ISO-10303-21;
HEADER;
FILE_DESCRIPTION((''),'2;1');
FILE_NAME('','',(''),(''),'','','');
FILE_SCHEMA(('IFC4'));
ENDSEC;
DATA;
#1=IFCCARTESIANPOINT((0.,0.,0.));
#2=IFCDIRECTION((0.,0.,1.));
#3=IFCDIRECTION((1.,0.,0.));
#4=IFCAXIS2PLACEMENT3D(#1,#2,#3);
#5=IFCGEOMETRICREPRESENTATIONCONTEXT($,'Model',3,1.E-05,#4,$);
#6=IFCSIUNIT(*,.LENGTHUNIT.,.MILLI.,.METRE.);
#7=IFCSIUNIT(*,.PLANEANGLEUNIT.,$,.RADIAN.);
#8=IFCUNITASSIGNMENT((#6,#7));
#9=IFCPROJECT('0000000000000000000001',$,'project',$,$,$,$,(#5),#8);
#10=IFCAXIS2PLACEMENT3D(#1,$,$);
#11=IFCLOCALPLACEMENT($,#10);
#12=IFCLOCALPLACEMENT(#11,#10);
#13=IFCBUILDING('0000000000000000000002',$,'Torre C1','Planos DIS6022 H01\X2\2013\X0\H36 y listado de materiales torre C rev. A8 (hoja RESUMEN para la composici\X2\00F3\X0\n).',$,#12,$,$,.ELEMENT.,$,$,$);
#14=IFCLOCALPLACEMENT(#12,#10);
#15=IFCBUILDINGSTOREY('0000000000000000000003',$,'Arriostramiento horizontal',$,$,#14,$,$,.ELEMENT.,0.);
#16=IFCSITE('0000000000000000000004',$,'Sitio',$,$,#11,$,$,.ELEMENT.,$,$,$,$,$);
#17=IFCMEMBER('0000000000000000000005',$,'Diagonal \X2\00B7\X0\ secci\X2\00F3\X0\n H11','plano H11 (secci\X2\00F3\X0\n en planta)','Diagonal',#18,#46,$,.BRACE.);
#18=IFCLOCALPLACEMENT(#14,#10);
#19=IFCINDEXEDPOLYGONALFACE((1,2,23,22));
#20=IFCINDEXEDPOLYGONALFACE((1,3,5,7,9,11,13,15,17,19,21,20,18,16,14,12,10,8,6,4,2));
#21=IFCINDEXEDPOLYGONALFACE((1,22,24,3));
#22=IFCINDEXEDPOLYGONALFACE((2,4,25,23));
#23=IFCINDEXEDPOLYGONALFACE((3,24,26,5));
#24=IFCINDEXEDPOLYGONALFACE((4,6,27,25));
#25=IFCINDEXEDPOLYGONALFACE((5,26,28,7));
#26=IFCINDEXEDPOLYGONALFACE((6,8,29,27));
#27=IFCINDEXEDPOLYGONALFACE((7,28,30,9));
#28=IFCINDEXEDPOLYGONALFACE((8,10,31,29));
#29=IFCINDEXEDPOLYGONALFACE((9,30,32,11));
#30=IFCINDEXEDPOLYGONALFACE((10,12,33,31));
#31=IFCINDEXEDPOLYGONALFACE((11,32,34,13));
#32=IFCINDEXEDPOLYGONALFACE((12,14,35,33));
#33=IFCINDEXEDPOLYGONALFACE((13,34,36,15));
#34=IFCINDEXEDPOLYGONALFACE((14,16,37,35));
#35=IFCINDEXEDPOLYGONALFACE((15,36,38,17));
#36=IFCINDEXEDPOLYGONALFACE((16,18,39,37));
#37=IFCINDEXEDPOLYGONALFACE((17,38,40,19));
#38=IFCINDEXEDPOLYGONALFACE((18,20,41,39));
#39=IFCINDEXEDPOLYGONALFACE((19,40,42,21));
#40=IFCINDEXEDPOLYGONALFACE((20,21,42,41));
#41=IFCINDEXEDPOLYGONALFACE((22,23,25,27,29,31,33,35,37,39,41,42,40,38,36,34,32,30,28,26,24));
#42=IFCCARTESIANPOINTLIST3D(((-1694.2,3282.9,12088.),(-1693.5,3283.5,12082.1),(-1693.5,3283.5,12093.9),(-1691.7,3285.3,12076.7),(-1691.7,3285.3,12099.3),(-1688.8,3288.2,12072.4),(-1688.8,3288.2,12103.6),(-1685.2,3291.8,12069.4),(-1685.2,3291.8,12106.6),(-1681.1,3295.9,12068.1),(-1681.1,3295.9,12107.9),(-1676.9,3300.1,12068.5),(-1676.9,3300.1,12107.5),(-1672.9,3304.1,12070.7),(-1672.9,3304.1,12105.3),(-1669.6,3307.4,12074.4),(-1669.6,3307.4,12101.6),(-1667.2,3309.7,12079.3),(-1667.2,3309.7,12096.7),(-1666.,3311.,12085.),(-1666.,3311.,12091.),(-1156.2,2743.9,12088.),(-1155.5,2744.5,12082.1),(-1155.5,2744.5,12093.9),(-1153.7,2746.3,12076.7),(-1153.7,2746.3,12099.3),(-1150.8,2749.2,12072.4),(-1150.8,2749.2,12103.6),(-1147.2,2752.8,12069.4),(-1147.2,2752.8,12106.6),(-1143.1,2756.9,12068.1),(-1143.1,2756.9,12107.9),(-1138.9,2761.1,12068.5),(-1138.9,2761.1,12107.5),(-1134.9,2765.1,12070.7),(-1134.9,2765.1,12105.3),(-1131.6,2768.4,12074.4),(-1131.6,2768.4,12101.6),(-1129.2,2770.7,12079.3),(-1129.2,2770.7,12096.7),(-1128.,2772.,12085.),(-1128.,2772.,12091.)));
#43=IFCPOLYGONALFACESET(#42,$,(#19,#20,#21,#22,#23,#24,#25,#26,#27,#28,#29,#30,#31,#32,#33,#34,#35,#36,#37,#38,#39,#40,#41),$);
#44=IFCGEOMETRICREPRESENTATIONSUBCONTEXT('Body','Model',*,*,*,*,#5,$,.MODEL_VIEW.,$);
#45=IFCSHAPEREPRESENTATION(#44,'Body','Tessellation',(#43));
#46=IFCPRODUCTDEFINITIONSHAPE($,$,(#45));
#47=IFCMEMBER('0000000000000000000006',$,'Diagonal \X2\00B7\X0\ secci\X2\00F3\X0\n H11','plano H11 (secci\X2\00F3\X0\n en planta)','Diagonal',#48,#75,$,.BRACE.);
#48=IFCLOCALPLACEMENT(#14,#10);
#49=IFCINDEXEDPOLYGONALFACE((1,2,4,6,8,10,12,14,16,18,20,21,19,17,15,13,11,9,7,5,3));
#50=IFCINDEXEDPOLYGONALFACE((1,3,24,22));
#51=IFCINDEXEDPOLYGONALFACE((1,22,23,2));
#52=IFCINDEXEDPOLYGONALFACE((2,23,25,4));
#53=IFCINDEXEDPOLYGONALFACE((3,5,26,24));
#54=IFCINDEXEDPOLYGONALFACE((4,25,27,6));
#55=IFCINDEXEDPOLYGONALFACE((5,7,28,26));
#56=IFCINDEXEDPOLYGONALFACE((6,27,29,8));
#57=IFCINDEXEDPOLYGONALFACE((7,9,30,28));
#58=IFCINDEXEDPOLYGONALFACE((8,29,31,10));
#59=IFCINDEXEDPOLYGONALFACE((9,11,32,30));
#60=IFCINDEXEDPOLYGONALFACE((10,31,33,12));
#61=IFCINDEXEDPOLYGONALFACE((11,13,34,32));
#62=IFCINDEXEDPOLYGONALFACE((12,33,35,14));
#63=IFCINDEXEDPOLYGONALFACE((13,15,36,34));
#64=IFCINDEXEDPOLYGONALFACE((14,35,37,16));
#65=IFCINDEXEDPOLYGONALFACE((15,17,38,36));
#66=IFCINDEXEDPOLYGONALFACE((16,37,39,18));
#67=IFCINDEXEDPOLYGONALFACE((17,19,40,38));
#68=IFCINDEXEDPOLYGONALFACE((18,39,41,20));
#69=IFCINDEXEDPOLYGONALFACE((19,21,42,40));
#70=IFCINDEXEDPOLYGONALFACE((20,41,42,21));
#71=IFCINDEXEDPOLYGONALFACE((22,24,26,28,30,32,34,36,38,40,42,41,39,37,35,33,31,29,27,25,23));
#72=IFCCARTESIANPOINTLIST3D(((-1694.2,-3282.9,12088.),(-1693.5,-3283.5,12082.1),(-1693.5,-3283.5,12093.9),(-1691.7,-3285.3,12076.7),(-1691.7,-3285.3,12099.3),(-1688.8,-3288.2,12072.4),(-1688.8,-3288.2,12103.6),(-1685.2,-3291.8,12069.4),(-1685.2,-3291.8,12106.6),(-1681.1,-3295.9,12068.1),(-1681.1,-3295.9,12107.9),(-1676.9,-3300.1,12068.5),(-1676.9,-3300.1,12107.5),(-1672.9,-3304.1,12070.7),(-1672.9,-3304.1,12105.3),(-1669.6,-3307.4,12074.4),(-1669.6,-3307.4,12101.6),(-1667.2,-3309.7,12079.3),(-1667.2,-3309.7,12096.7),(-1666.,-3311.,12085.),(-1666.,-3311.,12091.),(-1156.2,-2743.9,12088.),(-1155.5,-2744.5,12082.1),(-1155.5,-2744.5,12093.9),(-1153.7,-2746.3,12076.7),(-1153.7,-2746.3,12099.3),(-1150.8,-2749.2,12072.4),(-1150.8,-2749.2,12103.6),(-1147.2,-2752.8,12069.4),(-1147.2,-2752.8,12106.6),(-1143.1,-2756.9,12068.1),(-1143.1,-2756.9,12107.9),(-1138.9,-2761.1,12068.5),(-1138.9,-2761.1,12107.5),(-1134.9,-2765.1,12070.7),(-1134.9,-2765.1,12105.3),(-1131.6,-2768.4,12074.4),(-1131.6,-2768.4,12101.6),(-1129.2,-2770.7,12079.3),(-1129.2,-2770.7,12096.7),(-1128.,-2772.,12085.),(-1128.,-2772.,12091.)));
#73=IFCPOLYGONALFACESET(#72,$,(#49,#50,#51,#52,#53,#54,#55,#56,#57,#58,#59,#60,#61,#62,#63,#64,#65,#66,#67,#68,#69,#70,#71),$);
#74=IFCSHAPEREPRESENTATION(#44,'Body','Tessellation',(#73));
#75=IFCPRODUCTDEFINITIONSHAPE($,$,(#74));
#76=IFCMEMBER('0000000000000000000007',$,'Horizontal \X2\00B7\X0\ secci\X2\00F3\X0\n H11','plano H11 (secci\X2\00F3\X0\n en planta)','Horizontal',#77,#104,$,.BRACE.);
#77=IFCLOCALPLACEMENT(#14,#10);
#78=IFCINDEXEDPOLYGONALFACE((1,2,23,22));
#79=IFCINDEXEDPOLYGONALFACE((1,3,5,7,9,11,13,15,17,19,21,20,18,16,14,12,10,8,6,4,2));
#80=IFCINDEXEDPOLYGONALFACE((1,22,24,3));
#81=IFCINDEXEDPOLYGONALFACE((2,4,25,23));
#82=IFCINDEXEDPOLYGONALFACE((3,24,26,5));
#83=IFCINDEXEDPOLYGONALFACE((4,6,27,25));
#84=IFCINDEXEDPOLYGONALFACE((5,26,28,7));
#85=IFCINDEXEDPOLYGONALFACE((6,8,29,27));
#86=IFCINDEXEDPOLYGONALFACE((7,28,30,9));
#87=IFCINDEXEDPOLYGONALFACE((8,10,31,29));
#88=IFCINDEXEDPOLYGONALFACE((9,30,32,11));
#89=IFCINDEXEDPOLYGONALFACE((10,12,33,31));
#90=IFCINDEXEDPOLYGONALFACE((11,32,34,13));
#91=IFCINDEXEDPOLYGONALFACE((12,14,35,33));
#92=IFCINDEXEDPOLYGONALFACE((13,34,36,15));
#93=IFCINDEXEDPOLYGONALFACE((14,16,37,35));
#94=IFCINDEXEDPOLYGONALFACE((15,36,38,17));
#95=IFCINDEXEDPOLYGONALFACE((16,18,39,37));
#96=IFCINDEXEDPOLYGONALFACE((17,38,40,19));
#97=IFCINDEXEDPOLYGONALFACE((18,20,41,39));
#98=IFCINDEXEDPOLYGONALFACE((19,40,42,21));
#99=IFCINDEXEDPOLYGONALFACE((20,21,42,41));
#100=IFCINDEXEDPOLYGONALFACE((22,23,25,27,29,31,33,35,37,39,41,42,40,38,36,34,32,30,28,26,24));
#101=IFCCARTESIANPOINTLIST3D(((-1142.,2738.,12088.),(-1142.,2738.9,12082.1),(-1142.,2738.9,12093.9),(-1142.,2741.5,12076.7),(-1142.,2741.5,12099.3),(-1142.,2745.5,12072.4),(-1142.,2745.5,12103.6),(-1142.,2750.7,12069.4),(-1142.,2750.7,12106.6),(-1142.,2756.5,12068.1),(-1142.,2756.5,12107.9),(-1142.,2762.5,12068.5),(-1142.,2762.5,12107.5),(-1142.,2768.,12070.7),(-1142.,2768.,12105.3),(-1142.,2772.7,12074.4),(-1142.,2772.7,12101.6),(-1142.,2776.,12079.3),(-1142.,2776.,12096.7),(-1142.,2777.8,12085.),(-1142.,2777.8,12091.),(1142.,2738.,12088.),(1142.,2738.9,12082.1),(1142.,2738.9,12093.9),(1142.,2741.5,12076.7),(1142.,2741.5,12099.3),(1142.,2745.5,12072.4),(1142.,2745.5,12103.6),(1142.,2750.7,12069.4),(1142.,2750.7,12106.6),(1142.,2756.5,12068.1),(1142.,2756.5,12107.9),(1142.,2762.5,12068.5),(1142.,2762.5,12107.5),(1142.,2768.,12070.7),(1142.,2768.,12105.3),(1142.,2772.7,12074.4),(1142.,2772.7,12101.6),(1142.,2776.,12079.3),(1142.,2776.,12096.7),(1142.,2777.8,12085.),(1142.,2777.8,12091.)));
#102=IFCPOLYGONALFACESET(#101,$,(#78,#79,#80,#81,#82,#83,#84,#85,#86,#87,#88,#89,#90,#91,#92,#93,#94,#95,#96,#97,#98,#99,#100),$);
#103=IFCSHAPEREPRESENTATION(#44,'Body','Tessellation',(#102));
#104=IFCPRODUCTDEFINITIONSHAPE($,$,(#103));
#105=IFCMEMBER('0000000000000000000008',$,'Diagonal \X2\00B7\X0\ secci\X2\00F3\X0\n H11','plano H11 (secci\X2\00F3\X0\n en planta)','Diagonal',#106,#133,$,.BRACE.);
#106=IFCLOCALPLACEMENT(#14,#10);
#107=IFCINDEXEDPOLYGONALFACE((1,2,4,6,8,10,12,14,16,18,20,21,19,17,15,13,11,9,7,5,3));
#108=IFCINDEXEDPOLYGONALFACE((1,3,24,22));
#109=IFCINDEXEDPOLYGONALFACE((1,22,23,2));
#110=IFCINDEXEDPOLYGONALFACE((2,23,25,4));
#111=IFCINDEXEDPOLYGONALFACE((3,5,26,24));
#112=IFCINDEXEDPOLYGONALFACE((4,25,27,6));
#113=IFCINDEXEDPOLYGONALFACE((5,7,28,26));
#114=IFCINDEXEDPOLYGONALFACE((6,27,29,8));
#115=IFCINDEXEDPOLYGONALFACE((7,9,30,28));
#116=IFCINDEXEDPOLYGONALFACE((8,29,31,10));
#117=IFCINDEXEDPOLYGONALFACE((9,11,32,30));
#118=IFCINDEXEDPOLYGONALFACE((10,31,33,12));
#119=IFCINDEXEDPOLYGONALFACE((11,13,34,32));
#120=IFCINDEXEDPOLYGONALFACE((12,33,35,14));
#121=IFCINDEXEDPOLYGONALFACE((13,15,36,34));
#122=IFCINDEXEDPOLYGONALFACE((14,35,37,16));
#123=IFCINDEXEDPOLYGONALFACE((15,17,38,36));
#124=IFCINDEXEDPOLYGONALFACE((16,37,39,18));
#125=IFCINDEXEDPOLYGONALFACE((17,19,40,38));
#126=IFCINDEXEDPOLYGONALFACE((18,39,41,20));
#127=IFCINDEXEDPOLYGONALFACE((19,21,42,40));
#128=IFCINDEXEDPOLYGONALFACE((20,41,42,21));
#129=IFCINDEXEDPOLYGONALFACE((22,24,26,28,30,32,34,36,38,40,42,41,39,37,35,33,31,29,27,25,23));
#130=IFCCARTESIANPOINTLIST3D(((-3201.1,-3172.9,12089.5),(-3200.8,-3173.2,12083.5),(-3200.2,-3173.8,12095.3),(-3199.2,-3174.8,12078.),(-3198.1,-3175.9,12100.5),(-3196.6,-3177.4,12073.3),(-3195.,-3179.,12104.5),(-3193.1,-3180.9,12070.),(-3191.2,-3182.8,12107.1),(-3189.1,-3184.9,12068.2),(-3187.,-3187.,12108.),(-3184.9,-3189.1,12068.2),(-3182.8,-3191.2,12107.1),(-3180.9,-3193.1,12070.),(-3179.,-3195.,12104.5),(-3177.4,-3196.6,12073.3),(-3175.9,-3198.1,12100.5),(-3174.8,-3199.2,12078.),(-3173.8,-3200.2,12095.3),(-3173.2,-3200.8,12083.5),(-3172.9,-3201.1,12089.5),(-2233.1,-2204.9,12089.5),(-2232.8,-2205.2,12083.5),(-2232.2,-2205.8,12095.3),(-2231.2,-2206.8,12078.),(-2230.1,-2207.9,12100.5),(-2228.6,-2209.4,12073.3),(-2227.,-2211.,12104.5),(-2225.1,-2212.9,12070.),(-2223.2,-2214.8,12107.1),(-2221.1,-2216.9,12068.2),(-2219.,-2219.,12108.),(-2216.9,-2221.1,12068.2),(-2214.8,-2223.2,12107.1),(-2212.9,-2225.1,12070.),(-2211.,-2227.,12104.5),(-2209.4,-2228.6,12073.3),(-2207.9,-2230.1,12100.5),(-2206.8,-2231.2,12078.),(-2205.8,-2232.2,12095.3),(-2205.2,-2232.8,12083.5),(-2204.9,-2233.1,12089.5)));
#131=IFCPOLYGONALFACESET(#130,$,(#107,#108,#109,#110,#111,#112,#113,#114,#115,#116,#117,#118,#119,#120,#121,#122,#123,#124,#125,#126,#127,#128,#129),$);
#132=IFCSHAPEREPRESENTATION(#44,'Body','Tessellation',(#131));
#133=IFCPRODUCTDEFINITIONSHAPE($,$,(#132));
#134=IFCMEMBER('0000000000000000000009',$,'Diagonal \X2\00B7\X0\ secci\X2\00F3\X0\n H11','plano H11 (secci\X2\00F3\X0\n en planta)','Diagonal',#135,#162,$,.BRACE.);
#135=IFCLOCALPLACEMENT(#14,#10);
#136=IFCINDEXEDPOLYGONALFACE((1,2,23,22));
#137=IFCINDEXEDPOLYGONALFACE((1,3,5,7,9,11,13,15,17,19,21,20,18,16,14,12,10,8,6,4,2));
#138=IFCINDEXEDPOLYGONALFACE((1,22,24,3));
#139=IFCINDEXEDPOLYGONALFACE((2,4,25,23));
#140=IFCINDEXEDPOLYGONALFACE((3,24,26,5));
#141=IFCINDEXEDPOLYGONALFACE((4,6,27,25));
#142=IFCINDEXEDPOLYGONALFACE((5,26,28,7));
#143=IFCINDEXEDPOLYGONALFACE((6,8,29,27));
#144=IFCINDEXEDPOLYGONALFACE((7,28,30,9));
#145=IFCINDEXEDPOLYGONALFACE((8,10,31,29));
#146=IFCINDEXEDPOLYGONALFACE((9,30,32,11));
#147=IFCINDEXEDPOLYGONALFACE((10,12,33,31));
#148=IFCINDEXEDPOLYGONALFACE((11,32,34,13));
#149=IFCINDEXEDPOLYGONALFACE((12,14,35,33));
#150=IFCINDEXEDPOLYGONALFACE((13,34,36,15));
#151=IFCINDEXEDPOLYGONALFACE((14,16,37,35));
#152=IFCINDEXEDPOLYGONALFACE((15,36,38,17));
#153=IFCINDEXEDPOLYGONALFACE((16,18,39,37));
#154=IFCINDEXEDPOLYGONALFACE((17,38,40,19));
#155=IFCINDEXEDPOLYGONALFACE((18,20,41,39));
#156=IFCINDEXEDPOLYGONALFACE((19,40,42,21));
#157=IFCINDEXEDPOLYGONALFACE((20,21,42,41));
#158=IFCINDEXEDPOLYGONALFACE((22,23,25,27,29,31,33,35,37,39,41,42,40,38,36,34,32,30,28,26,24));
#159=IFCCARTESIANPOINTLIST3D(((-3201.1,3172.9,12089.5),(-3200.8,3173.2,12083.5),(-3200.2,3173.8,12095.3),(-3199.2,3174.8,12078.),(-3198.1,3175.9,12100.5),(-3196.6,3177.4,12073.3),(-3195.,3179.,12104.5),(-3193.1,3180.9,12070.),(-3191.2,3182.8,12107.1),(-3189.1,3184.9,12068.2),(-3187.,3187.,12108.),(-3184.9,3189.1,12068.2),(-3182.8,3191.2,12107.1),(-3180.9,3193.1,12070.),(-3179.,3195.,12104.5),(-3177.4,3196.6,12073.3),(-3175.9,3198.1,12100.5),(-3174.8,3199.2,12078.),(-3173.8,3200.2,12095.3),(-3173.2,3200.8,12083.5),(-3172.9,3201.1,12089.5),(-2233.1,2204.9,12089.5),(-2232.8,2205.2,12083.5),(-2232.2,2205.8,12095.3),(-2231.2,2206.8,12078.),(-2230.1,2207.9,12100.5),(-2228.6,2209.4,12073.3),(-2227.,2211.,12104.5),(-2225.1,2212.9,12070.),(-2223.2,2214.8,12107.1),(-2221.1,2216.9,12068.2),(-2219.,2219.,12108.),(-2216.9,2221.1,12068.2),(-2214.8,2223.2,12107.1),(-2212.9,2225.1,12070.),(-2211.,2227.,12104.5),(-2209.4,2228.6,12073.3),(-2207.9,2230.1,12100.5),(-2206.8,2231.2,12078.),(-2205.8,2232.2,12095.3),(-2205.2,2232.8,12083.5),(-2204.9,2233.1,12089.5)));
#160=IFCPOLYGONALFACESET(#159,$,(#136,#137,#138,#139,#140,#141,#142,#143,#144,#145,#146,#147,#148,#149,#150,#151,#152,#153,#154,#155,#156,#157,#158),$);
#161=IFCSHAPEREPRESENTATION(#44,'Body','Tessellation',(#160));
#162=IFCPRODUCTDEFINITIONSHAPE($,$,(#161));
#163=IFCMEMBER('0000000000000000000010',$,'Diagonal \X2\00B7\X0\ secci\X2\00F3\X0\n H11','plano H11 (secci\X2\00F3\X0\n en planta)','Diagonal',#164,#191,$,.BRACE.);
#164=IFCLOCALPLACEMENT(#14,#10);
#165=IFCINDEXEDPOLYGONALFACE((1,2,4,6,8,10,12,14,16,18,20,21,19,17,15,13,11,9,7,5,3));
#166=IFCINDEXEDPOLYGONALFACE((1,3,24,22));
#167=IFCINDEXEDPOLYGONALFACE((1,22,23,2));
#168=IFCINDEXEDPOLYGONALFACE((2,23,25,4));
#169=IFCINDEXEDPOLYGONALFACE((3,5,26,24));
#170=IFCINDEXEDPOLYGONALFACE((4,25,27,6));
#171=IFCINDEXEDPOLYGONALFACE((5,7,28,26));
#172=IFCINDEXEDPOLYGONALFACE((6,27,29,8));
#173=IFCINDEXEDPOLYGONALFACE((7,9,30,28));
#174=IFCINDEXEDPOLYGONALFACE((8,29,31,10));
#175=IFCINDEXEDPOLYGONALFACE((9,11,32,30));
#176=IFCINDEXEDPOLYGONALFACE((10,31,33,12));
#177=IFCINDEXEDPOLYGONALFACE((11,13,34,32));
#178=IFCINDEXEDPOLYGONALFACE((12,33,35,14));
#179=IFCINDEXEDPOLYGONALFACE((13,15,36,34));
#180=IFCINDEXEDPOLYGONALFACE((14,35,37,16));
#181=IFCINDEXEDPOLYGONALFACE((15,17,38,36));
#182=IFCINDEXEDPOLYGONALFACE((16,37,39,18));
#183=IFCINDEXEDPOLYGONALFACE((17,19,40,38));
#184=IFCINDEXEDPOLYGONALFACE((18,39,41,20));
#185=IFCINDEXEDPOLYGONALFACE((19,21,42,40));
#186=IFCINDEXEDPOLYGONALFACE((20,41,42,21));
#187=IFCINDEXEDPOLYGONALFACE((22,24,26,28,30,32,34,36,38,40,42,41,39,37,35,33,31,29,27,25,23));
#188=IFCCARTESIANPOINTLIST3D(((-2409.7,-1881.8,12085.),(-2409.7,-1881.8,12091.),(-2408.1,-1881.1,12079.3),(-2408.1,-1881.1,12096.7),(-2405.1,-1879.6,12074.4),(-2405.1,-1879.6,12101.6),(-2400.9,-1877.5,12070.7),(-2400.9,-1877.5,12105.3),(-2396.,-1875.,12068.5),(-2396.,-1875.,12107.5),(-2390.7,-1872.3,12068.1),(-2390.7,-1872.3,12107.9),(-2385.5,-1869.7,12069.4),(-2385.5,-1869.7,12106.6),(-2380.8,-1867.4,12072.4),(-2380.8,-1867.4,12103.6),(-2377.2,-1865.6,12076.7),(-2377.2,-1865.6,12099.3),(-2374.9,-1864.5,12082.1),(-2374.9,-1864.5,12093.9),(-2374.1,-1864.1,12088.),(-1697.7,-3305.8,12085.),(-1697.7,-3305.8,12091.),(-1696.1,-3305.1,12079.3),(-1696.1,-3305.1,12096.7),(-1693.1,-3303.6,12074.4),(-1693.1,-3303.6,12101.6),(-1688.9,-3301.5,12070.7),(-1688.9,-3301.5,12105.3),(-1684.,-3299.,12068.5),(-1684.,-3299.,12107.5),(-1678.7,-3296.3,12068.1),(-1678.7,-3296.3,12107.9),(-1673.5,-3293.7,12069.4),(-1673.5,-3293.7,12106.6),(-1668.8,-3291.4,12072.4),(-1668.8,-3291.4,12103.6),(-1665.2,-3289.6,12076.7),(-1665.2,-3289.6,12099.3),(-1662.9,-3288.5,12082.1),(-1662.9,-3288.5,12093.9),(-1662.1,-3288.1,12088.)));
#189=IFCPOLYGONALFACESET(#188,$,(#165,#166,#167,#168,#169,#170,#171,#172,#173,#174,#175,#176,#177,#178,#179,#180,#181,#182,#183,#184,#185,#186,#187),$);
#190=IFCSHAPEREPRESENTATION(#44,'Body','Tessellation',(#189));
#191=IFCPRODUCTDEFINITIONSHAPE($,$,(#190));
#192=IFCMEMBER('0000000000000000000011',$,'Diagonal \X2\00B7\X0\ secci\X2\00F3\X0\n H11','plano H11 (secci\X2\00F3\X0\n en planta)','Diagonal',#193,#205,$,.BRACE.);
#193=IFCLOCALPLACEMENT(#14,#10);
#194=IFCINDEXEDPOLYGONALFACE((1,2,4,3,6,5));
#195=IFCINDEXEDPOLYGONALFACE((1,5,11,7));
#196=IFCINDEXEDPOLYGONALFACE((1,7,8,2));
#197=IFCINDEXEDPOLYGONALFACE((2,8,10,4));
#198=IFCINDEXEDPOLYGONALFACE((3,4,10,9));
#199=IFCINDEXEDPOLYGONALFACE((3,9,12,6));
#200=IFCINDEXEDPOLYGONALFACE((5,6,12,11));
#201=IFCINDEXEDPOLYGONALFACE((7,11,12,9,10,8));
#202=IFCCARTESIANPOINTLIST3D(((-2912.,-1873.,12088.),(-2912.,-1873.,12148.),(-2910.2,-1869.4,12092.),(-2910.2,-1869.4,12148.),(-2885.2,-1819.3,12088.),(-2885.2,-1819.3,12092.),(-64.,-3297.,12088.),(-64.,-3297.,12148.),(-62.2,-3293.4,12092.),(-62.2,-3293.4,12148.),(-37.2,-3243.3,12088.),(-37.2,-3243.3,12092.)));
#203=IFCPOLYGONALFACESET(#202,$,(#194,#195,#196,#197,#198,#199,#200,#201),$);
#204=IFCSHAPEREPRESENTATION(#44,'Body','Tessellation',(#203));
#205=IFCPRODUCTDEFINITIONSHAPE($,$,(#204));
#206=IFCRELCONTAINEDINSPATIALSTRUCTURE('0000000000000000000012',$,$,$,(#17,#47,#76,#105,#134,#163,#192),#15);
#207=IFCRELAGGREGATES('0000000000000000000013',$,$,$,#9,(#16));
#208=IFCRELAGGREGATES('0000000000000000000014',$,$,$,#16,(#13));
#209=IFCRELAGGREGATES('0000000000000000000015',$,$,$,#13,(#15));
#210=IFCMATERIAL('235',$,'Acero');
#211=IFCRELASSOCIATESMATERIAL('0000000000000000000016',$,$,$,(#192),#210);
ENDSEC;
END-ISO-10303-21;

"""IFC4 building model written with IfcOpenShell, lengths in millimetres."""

from ifc_helpers import new_model, si_unit, frame, frame_2d, origin, origin_with_axes, place, context, subcontext, project, spatial, circle, l_section, extrude, material, element, save


model = new_model("IFC4")

# Units and contexts
model_context = context("Model", 3, precision=1e-05, world=origin_with_axes())
body_context = subcontext(model_context, "Body", "Model", "MODEL_VIEW")
ifc_project = project(units=[si_unit("LENGTHUNIT", "METRE", prefix="MILLI"), si_unit("PLANEANGLEUNIT", "RADIAN")], contexts=[model_context])

# Site, building, storey
site_placement = place(None, origin())
site = spatial("IfcSite", under=ifc_project, at=site_placement, Name="Sitio", CompositionType="ELEMENT")
building_placement = place(site_placement, origin())
building = spatial("IfcBuilding", under=site, at=building_placement, Name="Torre C1", Description="Planos DIS6022 H01–H36 y listado de materiales torre C rev. A8 (hoja RESUMEN para la composición).", CompositionType="ELEMENT")
storey_placement = place(building_placement, origin())
storey = spatial("IfcBuildingStorey", under=building, at=storey_placement, Name="Arriostramiento horizontal", CompositionType="ELEMENT", Elevation=0.0)

# Members
for number, where, z_axis, x_axis, name in (
    (1, (-1680.0, 3297.0, 12088.0), (0.70645, -0.707763, 0.0), (-0.707763, -0.70645, 0.0), "Diagonal · sección H11"),
    (2, (-1680.0, -3297.0, 12088.0), (0.70645, 0.707763, 0.0), (-0.707763, 0.70645, 0.0), "Diagonal · sección H11"),
):
    element("IfcMember", number, at=place(storey_placement, frame(where, z_axis=z_axis, x_axis=x_axis)), inside=storey, Name=name, Description="plano H11 (sección en planta)", ObjectType="Diagonal", PredefinedType="BRACE", context=body_context, shape_type="SweptSolid", body=[
        extrude(circle(Radius=20.0), None, (0.0, 0.0, 1.0), 761.6),
    ])
member_1_placement = place(storey_placement, frame((-1142.0, 2758.0, 12088.0), z_axis=(1.0, 0.0, 0.0), x_axis=(0.0, -1.0, 0.0)))
element("IfcMember", 3, at=member_1_placement, inside=storey, Name="Horizontal · sección H11", Description="plano H11 (sección en planta)", ObjectType="Horizontal", PredefinedType="BRACE", context=body_context, shape_type="SweptSolid", body=[
    extrude(circle(Radius=20.0), None, (0.0, 0.0, 1.0), 2284.0),
])
for number, where, z_axis, x_axis, name in (
    (4, (-3187.0, -3187.0, 12088.0), (0.707107, 0.707107, 0.0), (0.0, 0.0, 1.0), "Diagonal · sección H11"),
    (5, (-3187.0, 3187.0, 12088.0), (0.707107, -0.707107, 0.0), (0.0, 0.0, 1.0), "Diagonal · sección H11"),
):
    element("IfcMember", number, at=place(storey_placement, frame(where, z_axis=z_axis, x_axis=x_axis)), inside=storey, Name=name, Description="plano H11 (sección en planta)", ObjectType="Diagonal", PredefinedType="BRACE", context=body_context, shape_type="SweptSolid", body=[
        extrude(circle(Radius=20.0), None, (0.0, 0.0, 1.0), 1369.0),
    ])
member_2_placement = place(storey_placement, frame((-2392.0, -1873.0, 12088.0), z_axis=(0.447214, -0.894427, 0.0), x_axis=(0.894427, 0.447214, 0.0)))
element("IfcMember", 6, at=member_2_placement, inside=storey, Name="Diagonal · sección H11", Description="plano H11 (sección en planta)", ObjectType="Diagonal", PredefinedType="BRACE", context=body_context, shape_type="SweptSolid", body=[
    extrude(circle(Radius=20.0), None, (0.0, 0.0, 1.0), 1592.1),
])
ifc_material = material(Name="235", Category="Acero")
member_3_placement = place(storey_placement, frame((-2912.0, -1873.0, 12088.0), z_axis=(0.894427, -0.447214, 0.0), x_axis=(0.447214, 0.894427, 0.0)))
element("IfcMember", 7, at=member_3_placement, inside=storey, material=ifc_material, Name="Diagonal · sección H11", Description="plano H11 (sección en planta)", ObjectType="Diagonal", PredefinedType="BRACE", context=body_context, shape_type="SweptSolid", body=[
    extrude(l_section(Depth=60.0, Width=60.0, Thickness=4.0, at=frame_2d((30.0, 30.0))), None, (0.0, 0.0, 1.0), 3184.2),
])

save(model, "model.ifc")
